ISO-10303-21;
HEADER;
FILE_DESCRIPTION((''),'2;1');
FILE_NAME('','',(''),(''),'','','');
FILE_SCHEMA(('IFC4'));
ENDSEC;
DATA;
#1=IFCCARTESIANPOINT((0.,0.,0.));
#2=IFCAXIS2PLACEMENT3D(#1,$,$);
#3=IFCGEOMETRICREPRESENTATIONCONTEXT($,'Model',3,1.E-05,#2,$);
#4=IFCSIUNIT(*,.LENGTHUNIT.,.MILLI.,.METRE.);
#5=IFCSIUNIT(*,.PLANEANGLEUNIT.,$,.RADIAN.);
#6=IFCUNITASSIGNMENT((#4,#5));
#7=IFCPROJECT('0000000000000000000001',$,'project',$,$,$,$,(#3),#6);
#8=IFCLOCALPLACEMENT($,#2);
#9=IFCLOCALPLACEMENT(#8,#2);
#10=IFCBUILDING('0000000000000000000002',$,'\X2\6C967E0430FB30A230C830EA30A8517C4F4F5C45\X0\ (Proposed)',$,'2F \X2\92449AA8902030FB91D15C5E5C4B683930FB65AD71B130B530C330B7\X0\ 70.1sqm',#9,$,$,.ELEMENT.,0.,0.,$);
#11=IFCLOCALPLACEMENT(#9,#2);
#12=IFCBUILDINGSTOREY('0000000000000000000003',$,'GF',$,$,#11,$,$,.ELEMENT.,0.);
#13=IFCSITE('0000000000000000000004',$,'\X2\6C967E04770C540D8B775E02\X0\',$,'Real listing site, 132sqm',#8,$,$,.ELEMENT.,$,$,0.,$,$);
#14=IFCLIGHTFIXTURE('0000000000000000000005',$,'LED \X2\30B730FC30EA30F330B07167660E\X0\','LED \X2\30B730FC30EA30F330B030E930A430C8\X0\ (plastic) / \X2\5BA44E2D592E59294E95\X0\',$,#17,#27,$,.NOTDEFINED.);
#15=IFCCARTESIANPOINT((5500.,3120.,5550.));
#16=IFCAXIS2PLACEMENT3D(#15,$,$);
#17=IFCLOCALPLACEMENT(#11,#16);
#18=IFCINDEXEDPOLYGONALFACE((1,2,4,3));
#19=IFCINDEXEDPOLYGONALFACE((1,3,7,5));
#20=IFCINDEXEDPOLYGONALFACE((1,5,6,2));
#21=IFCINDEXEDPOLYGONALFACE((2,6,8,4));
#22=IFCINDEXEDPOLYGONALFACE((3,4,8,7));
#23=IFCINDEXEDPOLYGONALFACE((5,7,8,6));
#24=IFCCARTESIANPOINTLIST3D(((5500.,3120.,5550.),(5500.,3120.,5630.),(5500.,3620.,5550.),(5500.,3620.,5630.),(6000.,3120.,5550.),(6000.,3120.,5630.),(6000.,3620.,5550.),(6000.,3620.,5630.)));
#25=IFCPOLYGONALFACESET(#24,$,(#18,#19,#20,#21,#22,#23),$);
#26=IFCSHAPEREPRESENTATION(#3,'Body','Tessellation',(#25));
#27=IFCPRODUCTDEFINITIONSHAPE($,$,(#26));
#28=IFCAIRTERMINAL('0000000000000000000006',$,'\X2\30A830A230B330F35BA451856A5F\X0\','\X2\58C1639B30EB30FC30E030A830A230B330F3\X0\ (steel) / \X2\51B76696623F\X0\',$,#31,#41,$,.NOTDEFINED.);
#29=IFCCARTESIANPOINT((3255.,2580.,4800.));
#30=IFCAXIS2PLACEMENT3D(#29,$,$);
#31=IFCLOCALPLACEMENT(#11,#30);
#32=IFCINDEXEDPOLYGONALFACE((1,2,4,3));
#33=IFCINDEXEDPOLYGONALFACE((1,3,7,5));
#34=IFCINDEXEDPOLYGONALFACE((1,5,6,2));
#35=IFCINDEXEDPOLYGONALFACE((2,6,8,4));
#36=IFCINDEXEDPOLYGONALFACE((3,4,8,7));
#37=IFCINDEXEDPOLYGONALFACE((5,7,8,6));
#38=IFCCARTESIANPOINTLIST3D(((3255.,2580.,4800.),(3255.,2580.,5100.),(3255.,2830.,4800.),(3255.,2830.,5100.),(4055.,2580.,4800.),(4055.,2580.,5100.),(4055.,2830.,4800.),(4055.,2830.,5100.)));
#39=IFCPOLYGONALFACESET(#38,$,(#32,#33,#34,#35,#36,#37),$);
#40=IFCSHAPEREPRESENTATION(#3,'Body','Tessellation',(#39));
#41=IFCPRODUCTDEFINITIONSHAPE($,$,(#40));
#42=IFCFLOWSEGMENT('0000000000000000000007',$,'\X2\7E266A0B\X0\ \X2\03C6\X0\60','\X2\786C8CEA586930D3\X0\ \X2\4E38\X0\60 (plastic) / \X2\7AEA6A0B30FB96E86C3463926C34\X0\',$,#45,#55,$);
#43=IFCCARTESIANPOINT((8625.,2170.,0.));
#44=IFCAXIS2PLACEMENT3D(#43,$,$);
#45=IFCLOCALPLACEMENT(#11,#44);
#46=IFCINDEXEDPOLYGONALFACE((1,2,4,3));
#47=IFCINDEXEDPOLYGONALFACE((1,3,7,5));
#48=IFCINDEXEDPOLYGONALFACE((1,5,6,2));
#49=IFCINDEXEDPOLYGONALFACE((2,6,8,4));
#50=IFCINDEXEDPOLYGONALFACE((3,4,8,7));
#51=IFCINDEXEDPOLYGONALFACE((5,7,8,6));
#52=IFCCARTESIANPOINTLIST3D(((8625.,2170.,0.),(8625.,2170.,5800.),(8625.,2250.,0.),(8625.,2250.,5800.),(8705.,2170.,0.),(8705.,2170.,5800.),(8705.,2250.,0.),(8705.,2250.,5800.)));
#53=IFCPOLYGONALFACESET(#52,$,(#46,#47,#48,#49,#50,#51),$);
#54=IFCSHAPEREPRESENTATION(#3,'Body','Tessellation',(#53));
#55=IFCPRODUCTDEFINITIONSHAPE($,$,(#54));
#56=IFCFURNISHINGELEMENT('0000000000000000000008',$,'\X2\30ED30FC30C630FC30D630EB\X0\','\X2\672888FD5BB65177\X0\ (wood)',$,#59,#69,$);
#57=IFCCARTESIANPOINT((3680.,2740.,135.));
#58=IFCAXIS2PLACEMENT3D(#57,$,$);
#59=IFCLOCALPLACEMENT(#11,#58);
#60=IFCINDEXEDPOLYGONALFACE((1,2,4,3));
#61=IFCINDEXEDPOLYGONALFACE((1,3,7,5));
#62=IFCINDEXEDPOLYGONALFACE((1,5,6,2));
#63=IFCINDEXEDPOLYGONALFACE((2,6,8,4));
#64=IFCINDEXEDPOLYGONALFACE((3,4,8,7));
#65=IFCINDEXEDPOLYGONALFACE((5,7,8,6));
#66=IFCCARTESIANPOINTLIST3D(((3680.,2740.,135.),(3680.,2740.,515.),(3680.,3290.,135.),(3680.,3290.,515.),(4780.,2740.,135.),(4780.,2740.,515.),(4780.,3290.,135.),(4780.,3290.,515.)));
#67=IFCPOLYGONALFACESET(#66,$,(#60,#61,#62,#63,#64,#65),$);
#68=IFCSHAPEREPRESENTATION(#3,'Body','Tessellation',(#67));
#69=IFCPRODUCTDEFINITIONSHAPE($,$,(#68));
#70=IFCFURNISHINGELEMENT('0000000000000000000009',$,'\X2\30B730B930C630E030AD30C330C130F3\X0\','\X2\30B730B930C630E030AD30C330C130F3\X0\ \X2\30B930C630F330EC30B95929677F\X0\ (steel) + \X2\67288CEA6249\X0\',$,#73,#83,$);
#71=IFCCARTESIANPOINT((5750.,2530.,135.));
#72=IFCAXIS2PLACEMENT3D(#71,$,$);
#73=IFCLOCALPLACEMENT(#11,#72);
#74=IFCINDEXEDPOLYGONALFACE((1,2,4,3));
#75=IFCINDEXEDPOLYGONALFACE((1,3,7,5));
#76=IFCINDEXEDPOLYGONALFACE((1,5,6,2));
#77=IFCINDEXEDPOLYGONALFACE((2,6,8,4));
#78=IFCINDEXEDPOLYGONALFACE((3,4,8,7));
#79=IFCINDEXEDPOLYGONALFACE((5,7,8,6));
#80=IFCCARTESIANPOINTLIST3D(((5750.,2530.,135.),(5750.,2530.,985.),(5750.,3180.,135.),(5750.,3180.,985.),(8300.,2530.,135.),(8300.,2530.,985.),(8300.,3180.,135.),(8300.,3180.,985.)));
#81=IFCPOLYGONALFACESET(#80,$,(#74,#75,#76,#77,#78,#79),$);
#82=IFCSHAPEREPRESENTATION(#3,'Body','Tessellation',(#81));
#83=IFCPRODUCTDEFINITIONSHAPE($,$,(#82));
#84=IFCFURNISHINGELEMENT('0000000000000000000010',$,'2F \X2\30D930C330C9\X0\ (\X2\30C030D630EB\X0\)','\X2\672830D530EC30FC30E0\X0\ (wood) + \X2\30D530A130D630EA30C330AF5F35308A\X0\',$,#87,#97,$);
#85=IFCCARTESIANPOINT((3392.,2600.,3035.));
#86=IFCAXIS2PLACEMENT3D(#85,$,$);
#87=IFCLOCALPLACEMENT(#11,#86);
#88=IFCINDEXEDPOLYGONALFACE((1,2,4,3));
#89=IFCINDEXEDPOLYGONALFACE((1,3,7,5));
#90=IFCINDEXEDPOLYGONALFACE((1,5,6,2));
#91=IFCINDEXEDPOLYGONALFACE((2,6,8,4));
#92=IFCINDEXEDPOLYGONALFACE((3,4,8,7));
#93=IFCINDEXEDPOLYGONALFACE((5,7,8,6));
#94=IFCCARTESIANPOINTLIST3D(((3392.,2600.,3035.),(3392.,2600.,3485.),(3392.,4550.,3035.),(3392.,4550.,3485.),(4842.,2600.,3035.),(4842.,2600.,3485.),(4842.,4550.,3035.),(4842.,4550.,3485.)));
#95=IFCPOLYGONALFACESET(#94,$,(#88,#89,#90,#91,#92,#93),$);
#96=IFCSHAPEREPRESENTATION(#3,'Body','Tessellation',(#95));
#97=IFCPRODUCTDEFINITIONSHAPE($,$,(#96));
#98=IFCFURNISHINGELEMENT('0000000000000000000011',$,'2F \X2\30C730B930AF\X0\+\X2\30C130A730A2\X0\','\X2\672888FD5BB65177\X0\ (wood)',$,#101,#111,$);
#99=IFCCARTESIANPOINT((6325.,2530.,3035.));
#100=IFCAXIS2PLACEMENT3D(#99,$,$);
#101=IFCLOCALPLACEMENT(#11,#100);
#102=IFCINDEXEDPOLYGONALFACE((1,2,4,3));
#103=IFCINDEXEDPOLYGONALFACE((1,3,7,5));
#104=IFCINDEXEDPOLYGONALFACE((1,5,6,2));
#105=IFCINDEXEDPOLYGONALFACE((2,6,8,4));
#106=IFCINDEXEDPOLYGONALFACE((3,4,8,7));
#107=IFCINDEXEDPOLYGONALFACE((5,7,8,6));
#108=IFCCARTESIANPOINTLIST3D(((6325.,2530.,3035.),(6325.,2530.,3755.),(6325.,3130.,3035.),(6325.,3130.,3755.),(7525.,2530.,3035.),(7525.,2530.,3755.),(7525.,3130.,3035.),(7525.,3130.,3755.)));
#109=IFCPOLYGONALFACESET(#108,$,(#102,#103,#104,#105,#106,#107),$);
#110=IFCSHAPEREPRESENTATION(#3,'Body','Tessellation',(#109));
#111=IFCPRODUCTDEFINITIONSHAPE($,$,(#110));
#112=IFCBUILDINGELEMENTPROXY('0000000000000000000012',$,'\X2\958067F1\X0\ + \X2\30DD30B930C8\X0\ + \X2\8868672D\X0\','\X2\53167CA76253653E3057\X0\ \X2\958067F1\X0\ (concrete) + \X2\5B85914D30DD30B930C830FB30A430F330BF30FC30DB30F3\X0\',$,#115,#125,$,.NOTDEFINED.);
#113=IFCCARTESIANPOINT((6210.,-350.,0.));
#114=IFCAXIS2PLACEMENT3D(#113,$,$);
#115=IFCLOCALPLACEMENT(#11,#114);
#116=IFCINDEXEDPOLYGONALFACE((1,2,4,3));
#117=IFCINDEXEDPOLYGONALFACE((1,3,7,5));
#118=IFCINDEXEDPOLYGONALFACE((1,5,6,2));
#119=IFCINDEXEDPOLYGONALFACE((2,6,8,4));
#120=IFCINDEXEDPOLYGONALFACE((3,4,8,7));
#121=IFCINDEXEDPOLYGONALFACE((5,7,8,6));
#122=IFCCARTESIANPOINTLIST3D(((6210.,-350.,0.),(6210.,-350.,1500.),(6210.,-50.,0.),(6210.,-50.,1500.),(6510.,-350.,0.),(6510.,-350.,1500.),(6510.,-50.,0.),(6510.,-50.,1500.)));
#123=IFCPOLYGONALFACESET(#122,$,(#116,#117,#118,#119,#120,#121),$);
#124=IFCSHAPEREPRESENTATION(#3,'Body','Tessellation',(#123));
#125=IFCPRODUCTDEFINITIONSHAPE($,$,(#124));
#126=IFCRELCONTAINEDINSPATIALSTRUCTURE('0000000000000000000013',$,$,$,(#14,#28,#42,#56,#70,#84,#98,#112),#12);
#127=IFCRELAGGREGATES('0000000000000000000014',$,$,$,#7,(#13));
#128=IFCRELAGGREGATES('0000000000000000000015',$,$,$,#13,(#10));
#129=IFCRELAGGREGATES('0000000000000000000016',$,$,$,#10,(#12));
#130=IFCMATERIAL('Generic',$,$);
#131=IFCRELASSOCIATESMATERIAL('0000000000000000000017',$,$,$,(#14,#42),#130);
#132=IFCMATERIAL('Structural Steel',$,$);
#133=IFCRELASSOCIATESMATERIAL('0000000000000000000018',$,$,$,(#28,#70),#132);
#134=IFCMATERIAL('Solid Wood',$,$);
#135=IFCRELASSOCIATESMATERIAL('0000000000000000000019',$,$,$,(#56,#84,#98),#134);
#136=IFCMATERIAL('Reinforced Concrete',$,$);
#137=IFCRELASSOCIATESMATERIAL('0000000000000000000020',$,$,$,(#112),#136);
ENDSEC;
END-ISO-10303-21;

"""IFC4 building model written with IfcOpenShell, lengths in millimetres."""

from ifc_helpers import new_model, si_unit, frame, frame_2d, origin, place, context, project, spatial, rectangle, extrude, material, element, save


model = new_model("IFC4")

# Units and contexts
model_context = context("Model", 3, precision=1e-05, world=origin())
ifc_project = project(units=[si_unit("LENGTHUNIT", "METRE", prefix="MILLI"), si_unit("PLANEANGLEUNIT", "RADIAN")], contexts=[model_context])

# Site, building, storey
site_placement = place(None, origin())
site = spatial("IfcSite", under=ifc_project, at=site_placement, Name="沖縄県名護市", ObjectType="Real listing site, 132sqm", CompositionType="ELEMENT", RefElevation=0.0)
building_placement = place(site_placement, origin())
building = spatial("IfcBuilding", under=site, at=building_placement, Name="沖縄・アトリエ兼住居 (Proposed)", ObjectType="2F 鉄骨造・金属屋根・断熱サッシ 70.1sqm", CompositionType="ELEMENT", ElevationOfRefHeight=0.0, ElevationOfTerrain=0.0)
storey_placement = place(building_placement, origin())
storey = spatial("IfcBuildingStorey", under=building, at=storey_placement, Name="GF", CompositionType="ELEMENT", Elevation=0.0)

# Shared definitions
ifc_material_1 = material(Name="Solid Wood")

# Shared definitions
ifc_material_2 = material(Name="Reinforced Concrete")

# Shared definitions
ifc_material_3 = material(Name="Structural Steel")

# Shared definitions
ifc_material_4 = material(Name="Generic")

# Light fixture
light_fixture_1_placement = place(storey_placement, frame((5500.0, 3120.0, 5550.0)))
element("IfcLightFixture", 1, at=light_fixture_1_placement, inside=storey, material=ifc_material_4, Name="LED シーリング照明", Description="LED シーリングライト (plastic) / 室中央天井", PredefinedType="NOTDEFINED", context=model_context, shape_type="SweptSolid", body=[
    extrude(rectangle(XDim=500.0, YDim=500.0, at=frame_2d((250.0, 250.0))), frame((5500.0, 3120.0, 5550.0)), (0.0, 0.0, 1.0), 80.0),
])

# Air terminal
air_terminal_placement = place(storey_placement, frame((3255.0, 2580.0, 4800.0)))
element("IfcAirTerminal", 2, at=air_terminal_placement, inside=storey, material=ifc_material_3, Name="エアコン室内機", Description="壁掛ルームエアコン (steel) / 冷暖房", PredefinedType="NOTDEFINED", context=model_context, shape_type="SweptSolid", body=[
    extrude(rectangle(XDim=800.0, YDim=250.0, at=frame_2d((400.0, 125.0))), frame((3255.0, 2580.0, 4800.0)), (0.0, 0.0, 1.0), 300.0),
])

# Flow segment
flow_segment_placement = place(storey_placement, frame((8625.0, 2170.0, 0.0)))
element("IfcFlowSegment", 3, at=flow_segment_placement, inside=storey, material=ifc_material_4, Name="縦樋 φ60", Description="硬質塩ビ 丸60 (plastic) / 竪樋・雨水排水", context=model_context, shape_type="SweptSolid", body=[
    extrude(rectangle(XDim=80.0, YDim=80.0, at=frame_2d((40.0, 40.0))), frame((8625.0, 2170.0, 0.0)), (0.0, 0.0, 1.0), 5800.0),
])

# Furnishing elements
furnishing_1_placement = place(storey_placement, frame((3680.0, 2740.0, 135.0)))
element("IfcFurnishingElement", 4, at=furnishing_1_placement, inside=storey, material=ifc_material_1, Name="ローテーブル", Description="木製家具 (wood)", context=model_context, shape_type="SweptSolid", body=[
    extrude(rectangle(XDim=1100.0, YDim=550.0, at=frame_2d((550.0, 275.0))), frame((3680.0, 2740.0, 135.0)), (0.0, 0.0, 1.0), 380.0),
])
furnishing_2_placement = place(storey_placement, frame((5750.0, 2530.0, 135.0)))
element("IfcFurnishingElement", 5, at=furnishing_2_placement, inside=storey, material=ifc_material_3, Name="システムキッチン", Description="システムキッチン ステンレス天板 (steel) + 木質扉", context=model_context, shape_type="SweptSolid", body=[
    extrude(rectangle(XDim=2550.0, YDim=650.0, at=frame_2d((1275.0, 325.0))), frame((5750.0, 2530.0, 135.0)), (0.0, 0.0, 1.0), 850.0),
])
furnishing_3_placement = place(storey_placement, frame((3392.0, 2600.0, 3035.0)))
element("IfcFurnishingElement", 6, at=furnishing_3_placement, inside=storey, material=ifc_material_1, Name="2F ベッド (ダブル)", Description="木フレーム (wood) + ファブリック張り", context=model_context, shape_type="SweptSolid", body=[
    extrude(rectangle(XDim=1450.0, YDim=1950.0, at=frame_2d((725.0, 975.0))), frame((3392.0, 2600.0, 3035.0)), (0.0, 0.0, 1.0), 450.0),
])
furnishing_4_placement = place(storey_placement, frame((6325.0, 2530.0, 3035.0)))
element("IfcFurnishingElement", 7, at=furnishing_4_placement, inside=storey, material=ifc_material_1, Name="2F デスク+チェア", Description="木製家具 (wood)", context=model_context, shape_type="SweptSolid", body=[
    extrude(rectangle(XDim=1200.0, YDim=600.0, at=frame_2d((600.0, 300.0))), frame((6325.0, 2530.0, 3035.0)), (0.0, 0.0, 1.0), 720.0),
])

# Building element proxy
proxy_placement = place(storey_placement, frame((6210.0, -350.0, 0.0)))
element("IfcBuildingElementProxy", 8, at=proxy_placement, inside=storey, material=ifc_material_2, Name="門柱 + ポスト + 表札", Description="化粧打放し 門柱 (concrete) + 宅配ポスト・インターホン", PredefinedType="NOTDEFINED", context=model_context, shape_type="SweptSolid", body=[
    extrude(rectangle(XDim=300.0, YDim=300.0, at=frame_2d((150.0, 150.0))), frame((6210.0, -350.0, 0.0)), (0.0, 0.0, 1.0), 1500.0),
])

save(model, "model.ifc")
